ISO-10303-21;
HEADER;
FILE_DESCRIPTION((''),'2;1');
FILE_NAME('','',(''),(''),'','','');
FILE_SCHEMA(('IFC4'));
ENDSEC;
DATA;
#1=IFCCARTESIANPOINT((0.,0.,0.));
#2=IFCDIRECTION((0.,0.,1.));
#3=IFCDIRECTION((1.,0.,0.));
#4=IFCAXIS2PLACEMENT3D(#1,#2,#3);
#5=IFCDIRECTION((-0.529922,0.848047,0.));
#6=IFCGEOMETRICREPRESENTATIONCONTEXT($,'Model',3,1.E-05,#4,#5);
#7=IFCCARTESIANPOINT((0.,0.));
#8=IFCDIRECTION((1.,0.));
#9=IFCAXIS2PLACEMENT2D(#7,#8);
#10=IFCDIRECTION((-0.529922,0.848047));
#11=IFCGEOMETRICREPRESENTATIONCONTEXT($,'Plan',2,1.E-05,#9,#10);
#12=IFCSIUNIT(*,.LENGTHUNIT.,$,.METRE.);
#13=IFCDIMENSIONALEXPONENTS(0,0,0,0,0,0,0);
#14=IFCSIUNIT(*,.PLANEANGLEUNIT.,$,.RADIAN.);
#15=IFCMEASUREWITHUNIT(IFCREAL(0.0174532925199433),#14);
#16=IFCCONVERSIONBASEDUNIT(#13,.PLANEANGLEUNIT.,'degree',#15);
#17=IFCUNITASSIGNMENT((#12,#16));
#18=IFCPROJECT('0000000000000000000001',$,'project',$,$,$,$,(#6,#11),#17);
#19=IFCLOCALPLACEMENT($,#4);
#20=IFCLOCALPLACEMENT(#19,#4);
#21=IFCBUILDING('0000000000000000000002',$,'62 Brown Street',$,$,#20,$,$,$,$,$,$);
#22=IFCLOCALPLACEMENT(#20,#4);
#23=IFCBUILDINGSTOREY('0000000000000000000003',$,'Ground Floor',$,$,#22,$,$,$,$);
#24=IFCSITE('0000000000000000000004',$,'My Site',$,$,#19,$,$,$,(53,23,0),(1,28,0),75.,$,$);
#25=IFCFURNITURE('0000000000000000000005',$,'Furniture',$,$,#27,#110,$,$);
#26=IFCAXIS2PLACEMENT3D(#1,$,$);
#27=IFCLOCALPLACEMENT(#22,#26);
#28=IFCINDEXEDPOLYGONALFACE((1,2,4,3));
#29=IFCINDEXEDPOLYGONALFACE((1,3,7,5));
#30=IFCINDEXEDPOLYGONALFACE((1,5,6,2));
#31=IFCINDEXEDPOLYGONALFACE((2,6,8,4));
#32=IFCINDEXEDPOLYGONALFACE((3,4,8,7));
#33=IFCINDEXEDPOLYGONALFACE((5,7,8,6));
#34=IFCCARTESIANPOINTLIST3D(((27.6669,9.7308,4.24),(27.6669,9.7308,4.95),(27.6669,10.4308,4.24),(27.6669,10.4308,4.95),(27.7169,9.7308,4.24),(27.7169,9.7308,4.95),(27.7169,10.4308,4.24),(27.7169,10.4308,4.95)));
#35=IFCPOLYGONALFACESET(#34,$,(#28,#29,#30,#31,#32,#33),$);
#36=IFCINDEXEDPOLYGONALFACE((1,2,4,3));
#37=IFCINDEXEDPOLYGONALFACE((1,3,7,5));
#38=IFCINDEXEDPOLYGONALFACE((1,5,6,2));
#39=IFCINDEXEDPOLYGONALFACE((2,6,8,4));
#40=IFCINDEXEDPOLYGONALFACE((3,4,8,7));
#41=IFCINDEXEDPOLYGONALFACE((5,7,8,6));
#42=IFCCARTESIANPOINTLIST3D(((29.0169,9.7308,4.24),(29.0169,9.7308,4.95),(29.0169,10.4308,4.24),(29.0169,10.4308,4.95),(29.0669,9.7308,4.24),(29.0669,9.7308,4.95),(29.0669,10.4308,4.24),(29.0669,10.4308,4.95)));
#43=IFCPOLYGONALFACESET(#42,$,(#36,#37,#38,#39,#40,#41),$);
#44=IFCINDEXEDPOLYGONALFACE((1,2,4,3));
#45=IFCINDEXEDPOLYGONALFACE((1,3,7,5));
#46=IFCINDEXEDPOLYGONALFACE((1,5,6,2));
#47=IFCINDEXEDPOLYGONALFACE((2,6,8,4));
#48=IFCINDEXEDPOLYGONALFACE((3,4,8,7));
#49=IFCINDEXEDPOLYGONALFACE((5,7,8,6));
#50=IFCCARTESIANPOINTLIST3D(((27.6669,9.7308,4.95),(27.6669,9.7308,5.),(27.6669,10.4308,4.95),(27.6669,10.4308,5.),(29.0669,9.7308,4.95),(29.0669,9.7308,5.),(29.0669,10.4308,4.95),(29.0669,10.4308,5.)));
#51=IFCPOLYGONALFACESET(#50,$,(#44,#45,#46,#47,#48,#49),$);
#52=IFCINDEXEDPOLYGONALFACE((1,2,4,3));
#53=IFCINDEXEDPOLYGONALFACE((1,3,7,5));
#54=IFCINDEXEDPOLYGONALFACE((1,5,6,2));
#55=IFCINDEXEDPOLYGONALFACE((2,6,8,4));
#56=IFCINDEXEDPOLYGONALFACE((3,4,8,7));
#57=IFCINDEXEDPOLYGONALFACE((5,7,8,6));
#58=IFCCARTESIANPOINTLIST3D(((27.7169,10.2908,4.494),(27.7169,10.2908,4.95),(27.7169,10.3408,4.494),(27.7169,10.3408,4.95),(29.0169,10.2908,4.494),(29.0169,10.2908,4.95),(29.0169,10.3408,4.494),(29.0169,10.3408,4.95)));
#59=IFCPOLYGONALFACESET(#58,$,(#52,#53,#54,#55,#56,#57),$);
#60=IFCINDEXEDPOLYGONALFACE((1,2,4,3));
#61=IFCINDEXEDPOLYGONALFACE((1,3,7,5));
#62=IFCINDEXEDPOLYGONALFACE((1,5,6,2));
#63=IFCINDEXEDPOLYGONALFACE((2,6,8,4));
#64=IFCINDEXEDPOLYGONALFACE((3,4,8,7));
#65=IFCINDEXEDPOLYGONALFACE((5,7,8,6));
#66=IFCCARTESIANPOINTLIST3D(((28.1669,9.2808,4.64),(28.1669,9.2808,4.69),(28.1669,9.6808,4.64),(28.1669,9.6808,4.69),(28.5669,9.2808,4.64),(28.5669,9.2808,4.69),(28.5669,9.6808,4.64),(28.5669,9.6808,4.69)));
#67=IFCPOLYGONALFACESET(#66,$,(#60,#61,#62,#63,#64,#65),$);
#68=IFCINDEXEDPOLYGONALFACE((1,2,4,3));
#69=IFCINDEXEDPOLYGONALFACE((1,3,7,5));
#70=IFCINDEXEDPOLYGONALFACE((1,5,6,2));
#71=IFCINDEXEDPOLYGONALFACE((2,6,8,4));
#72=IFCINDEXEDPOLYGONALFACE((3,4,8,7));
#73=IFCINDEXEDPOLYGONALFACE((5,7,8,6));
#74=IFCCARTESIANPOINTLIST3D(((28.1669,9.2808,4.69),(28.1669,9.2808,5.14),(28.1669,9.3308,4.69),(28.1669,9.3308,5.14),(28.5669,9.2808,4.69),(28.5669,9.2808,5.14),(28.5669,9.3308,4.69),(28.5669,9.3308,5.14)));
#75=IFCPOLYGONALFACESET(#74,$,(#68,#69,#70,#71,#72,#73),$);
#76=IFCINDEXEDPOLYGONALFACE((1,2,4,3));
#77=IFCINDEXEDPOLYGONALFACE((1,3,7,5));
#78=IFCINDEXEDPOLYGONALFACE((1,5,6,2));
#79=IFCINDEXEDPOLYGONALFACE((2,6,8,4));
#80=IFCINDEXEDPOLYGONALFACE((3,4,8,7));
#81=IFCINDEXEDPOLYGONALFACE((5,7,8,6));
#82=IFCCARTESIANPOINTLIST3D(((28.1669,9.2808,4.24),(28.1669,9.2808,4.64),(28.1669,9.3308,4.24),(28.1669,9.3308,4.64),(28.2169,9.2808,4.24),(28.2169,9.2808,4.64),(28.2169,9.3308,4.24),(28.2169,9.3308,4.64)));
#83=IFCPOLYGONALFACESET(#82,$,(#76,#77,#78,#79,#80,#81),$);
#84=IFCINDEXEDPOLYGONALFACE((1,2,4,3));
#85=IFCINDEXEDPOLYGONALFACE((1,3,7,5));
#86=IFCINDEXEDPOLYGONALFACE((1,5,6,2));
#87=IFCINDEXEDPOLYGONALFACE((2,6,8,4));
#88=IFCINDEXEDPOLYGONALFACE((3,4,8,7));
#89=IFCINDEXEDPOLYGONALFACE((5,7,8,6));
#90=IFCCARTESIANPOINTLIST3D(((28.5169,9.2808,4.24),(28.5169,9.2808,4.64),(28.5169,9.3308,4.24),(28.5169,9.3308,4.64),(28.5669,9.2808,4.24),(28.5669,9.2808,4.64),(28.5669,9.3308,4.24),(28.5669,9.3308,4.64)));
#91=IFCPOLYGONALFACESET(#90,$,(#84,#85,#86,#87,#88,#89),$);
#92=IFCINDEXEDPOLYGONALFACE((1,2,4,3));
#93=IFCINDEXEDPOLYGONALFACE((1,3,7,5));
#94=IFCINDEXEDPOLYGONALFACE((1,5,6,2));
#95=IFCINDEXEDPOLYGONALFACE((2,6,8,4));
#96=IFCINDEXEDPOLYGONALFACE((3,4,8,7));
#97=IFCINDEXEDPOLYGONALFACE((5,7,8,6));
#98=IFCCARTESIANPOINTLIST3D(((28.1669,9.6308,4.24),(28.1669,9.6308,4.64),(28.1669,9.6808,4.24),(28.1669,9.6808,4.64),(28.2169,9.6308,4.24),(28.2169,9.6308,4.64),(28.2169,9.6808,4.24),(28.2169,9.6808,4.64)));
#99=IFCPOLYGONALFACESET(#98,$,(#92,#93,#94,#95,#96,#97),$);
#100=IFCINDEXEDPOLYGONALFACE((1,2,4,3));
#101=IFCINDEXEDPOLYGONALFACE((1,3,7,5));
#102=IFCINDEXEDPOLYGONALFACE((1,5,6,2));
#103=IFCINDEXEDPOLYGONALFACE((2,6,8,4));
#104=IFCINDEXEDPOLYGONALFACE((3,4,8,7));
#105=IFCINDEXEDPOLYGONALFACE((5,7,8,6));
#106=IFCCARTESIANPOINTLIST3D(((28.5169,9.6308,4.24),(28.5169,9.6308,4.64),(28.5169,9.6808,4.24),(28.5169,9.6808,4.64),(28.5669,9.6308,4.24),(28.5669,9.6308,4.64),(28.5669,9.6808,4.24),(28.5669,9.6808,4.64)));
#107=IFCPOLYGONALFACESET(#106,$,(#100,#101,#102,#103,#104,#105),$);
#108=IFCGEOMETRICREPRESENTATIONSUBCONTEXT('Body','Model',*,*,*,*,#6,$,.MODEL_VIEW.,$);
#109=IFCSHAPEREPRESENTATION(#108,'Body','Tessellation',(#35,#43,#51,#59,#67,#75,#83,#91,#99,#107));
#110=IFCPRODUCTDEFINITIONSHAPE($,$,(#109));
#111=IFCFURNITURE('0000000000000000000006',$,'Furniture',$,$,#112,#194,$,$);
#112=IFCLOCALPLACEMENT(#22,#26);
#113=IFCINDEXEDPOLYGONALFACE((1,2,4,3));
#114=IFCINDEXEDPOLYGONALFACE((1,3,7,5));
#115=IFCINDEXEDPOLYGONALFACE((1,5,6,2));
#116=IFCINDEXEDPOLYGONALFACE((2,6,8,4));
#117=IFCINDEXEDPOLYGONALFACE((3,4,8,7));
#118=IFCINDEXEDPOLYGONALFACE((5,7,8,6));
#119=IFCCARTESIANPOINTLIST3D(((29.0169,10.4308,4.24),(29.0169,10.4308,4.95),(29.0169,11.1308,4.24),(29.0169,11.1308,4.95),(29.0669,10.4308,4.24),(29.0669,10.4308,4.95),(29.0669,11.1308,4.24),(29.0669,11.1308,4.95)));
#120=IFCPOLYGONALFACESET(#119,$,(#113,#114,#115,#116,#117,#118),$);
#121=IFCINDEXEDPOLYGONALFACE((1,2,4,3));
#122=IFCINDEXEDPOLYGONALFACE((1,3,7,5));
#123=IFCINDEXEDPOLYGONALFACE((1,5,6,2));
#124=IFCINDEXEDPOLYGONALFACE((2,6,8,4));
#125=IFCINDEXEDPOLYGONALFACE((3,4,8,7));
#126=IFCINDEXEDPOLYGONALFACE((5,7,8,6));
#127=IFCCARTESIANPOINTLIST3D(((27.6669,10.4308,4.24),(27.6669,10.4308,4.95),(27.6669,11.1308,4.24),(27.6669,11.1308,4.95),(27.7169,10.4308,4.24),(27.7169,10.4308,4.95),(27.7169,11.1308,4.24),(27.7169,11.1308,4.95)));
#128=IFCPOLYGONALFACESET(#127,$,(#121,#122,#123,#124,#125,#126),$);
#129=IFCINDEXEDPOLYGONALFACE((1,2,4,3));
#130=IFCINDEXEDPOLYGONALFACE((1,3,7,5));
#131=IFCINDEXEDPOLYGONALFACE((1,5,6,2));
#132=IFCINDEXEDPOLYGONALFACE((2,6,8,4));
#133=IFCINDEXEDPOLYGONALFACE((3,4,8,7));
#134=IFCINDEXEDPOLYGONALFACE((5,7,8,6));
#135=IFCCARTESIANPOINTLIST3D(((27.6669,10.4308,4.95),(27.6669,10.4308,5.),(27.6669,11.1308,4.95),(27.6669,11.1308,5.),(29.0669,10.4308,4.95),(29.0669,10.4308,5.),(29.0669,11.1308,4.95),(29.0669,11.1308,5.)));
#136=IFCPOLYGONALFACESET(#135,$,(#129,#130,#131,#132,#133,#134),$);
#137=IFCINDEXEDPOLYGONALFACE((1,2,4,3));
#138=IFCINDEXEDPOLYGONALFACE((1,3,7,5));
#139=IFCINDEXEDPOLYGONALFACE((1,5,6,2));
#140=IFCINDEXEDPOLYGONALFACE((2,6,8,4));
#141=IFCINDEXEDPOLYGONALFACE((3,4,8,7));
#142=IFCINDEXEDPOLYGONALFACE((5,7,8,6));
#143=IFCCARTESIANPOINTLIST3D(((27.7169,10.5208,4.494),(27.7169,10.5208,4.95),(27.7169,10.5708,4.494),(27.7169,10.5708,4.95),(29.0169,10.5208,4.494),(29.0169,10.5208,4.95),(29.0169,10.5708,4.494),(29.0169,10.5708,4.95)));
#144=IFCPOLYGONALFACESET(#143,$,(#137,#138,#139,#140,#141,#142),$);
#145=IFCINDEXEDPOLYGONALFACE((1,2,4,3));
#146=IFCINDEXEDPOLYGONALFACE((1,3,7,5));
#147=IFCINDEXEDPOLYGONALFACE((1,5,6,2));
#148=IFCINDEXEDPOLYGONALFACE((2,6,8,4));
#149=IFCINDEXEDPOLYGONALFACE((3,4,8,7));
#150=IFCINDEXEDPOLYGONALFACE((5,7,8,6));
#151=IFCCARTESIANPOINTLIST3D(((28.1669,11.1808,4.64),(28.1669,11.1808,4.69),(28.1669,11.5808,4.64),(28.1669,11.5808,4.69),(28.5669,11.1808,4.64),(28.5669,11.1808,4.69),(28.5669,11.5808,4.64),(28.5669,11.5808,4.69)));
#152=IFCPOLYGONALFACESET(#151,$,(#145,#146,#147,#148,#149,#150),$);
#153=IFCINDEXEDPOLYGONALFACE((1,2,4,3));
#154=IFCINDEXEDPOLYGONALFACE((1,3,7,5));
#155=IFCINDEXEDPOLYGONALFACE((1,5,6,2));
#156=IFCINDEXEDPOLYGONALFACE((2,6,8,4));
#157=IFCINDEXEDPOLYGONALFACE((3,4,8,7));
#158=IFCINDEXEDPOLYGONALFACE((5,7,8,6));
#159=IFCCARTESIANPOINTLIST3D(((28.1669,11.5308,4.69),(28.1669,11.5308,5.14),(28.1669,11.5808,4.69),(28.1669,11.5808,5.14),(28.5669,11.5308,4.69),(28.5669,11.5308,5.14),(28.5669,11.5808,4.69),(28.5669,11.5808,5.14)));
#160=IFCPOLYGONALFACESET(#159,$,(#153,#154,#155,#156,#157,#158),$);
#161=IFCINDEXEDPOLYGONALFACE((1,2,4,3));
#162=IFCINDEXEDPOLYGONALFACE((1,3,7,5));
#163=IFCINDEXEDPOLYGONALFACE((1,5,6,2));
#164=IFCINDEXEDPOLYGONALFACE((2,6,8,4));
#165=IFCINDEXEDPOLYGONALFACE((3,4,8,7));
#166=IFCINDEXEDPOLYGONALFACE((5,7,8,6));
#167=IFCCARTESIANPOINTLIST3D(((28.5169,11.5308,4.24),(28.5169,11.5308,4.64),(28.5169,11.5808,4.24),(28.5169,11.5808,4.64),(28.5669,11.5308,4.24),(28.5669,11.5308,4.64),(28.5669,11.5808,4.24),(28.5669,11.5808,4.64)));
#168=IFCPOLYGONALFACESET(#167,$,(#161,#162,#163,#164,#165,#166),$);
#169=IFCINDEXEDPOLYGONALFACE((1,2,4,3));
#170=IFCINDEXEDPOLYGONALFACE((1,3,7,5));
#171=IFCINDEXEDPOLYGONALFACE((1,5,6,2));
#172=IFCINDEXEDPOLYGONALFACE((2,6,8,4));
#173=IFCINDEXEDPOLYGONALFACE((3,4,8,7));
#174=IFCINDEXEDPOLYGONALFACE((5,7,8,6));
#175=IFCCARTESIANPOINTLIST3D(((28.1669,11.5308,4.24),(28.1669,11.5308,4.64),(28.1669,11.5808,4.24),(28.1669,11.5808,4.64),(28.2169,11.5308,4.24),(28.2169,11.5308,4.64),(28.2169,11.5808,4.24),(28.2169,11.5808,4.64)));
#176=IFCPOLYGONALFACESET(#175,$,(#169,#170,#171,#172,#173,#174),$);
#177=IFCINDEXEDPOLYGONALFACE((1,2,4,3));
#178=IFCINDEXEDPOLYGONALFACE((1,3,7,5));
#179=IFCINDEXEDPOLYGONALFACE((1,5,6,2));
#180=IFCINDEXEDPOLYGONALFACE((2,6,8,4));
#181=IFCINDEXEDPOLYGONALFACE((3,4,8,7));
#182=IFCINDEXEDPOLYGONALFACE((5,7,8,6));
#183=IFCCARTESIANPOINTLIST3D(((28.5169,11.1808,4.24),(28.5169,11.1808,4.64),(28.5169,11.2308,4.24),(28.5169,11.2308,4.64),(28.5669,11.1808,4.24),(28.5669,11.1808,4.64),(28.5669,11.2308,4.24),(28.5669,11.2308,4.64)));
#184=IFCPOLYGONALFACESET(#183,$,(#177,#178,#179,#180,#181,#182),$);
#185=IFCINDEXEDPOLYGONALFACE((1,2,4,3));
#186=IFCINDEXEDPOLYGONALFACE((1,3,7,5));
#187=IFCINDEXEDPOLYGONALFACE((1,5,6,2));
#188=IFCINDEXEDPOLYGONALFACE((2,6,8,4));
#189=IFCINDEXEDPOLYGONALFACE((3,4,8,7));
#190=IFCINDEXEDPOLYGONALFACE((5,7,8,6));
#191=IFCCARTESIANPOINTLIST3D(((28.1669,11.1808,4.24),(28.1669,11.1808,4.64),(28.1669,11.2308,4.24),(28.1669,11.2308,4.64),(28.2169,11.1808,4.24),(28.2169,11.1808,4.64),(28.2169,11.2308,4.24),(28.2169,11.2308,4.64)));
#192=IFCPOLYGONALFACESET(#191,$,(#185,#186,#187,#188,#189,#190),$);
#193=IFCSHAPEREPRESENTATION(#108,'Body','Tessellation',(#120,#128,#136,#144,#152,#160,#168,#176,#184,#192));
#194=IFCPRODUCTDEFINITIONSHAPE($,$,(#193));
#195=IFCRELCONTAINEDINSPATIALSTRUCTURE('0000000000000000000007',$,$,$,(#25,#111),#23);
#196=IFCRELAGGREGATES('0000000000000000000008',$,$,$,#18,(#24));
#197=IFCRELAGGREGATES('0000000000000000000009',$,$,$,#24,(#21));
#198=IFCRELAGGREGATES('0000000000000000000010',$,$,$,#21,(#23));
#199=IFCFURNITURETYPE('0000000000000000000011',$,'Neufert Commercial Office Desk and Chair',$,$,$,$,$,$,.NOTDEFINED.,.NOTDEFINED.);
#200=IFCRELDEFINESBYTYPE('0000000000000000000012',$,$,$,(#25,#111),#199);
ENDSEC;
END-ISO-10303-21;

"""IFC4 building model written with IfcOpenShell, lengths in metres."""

from ifc_helpers import new_model, entity, si_unit, converted_unit, direction, frame, origin_with_axes, origin_2d_with_axis, place, context, subcontext, project, spatial, line, indexed_curve, outline, extrude, shape, source, transform, mapped, type_object, type_shapes, element, save


model = new_model("IFC4")

# Units and contexts
model_context = context("Model", 3, precision=1e-05, world=origin_with_axes(), true_north=direction((-0.529922, 0.848047, 0.0)))
plan_context = context("Plan", 2, precision=1e-05, world=origin_2d_with_axis(), true_north=direction((-0.529922, 0.848047)))
body_context_1 = subcontext(model_context, "Body", "Model", "MODEL_VIEW")
body_context_2 = subcontext(plan_context, "Body", "Plan", "PLAN_VIEW")
ifc_project = project(units=[si_unit("LENGTHUNIT", "METRE"), converted_unit("PLANEANGLEUNIT", "degree", entity("IfcReal", 0.0174532925199433), si_unit("PLANEANGLEUNIT", "RADIAN"), dimensions=[0, 0, 0, 0, 0, 0, 0])], contexts=[model_context, plan_context])

# Site, building, storey
site_placement = place(None, origin_with_axes())
site = spatial("IfcSite", under=ifc_project, at=site_placement, Name="My Site", RefLatitude=(53, 23, 0), RefLongitude=(1, 28, 0), RefElevation=75.0)
building_placement = place(site_placement, origin_with_axes())
building = spatial("IfcBuilding", under=site, at=building_placement, Name="62 Brown Street")
storey_placement = place(building_placement, origin_with_axes())
storey = spatial("IfcBuildingStorey", under=building, at=storey_placement, Name="Ground Floor")

# Furniture
furniture_type_1 = type_object("IfcFurnitureType", Name="Neufert Commercial Office Desk and Chair", AssemblyPlace="NOTDEFINED", PredefinedType="NOTDEFINED")
shared_shape_1 = source(origin_with_axes(), body_context_1, "Body", "SweptSolid", [
    extrude(outline(indexed_curve([(0.0, 0.0), (0.05, 0.0), (0.05, 0.7), (0.0, 0.7)], segments=[line(1, 2, 3, 4, 1)])), frame((0.0, 0.45, 0.0), z_axis=(0.0, 0.0, 1.0), x_axis=(1.0, 0.0, 0.0)), (0.0, 0.0, 1.0), 0.71),
    extrude(outline(indexed_curve([(0.0, 0.0), (0.05, 0.0), (0.05, 0.7), (0.0, 0.7)], segments=[line(1, 2, 3, 4, 1)])), frame((1.35, 0.45, 0.0), z_axis=(0.0, 0.0, 1.0), x_axis=(1.0, 0.0, 0.0)), (0.0, 0.0, 1.0), 0.71),
    extrude(outline(indexed_curve([(0.0, 0.0), (1.4, 0.0), (1.4, 0.7), (0.0, 0.7)], segments=[line(1, 2, 3, 4, 1)])), frame((0.0, 0.45, 0.71), z_axis=(0.0, 0.0, 1.0), x_axis=(1.0, 0.0, 0.0)), (0.0, 0.0, 1.0), 0.05),
    extrude(outline(indexed_curve([(0.05, 0.56), (1.35, 0.56), (1.35, 0.61), (0.05, 0.61)], segments=[line(1, 2, 3, 4, 1)])), frame((0.0, 0.45, 0.254), z_axis=(0.0, 0.0, 1.0), x_axis=(1.0, 0.0, 0.0)), (0.0, 0.0, 1.0), 0.456),
    extrude(outline(indexed_curve([(-0.2, 0.0), (0.2, 0.0), (0.2, 0.4), (-0.2, 0.4)], segments=[line(1, 2, 3, 4, 1)])), frame((0.7, 0.0, 0.45), z_axis=(0.0, 0.0, 1.0), x_axis=(1.0, 0.0, 0.0)), (0.0, 0.0, -1.0), 0.05),
    extrude(outline(indexed_curve([(-0.2, 0.0), (0.2, 0.0), (0.2, 0.05), (-0.2, 0.05)], segments=[line(1, 2, 3, 4, 1)])), frame((0.7, 0.0, 0.9), z_axis=(0.0, 0.0, 1.0), x_axis=(1.0, 0.0, 0.0)), (0.0, 0.0, -1.0), 0.45),
    extrude(outline(indexed_curve([(-0.2, 0.0), (-0.15, 0.0), (-0.15, 0.05), (-0.2, 0.05)], segments=[line(1, 2, 3, 4, 1)])), frame((0.7, 0.0, 0.0), z_axis=(0.0, 0.0, 1.0), x_axis=(1.0, 0.0, 0.0)), (0.0, 0.0, 1.0), 0.4),
    extrude(outline(indexed_curve([(0.2, 0.0), (0.15, 0.0), (0.15, 0.05), (0.2, 0.05)], segments=[line(1, 2, 3, 4, 1)])), frame((0.7, 0.0, 0.0), z_axis=(0.0, 0.0, 1.0), x_axis=(1.0, 0.0, 0.0)), (0.0, 0.0, 1.0), 0.4),
    extrude(outline(indexed_curve([(-0.2, 0.4), (-0.15, 0.4), (-0.15, 0.35), (-0.2, 0.35)], segments=[line(1, 2, 3, 4, 1)])), frame((0.7, 0.0, 0.0), z_axis=(0.0, 0.0, 1.0), x_axis=(1.0, 0.0, 0.0)), (0.0, 0.0, 1.0), 0.4),
    extrude(outline(indexed_curve([(0.2, 0.4), (0.15, 0.4), (0.15, 0.35), (0.2, 0.35)], segments=[line(1, 2, 3, 4, 1)])), frame((0.7, 0.0, 0.0), z_axis=(0.0, 0.0, 1.0), x_axis=(1.0, 0.0, 0.0)), (0.0, 0.0, 1.0), 0.4),
])
shared_shape_2 = source(origin_with_axes(), body_context_2, "Body", "Curve2D", [
    entity("IfcIndexedPolyCurve", entity("IfcCartesianPointList2D", [[0.0, 0.45], [1.4, 0.45], [1.4, 1.15], [0.0, 1.15]]), [entity("IfcLineIndex", [1, 2, 3, 4, 1])]),
    entity("IfcIndexedPolyCurve", entity("IfcCartesianPointList2D", [[0.5, 0.4], [0.9, 0.4]])),
    entity("IfcIndexedPolyCurve", entity("IfcCartesianPointList2D", [[0.5, 0.4], [0.5, 0.2], [0.5586, 0.0586], [0.7, 0.0], [0.8414, 0.0586], [0.9, 0.2], [0.9, 0.4]]), [entity("IfcLineIndex", [1, 2]), entity("IfcArcIndex", [2, 3, 4]), entity("IfcArcIndex", [4, 5, 6]), entity("IfcLineIndex", [6, 7])]),
    entity("IfcIndexedPolyCurve", entity("IfcCartesianPointList2D", [[0.54, 0.4], [0.54, 0.2], [0.5869, 0.0869], [0.7, 0.04], [0.8131, 0.0869], [0.86, 0.2], [0.86, 0.4]]), [entity("IfcLineIndex", [1, 2]), entity("IfcArcIndex", [2, 3, 4]), entity("IfcArcIndex", [4, 5, 6]), entity("IfcLineIndex", [6, 7])]),
])
type_shapes(furniture_type_1, [shared_shape_1, shared_shape_2])
for number, where, z_axis, x_axis, name in (
    (1, (27.6669, 9.2808, 4.24), (0.0, 0.0, 1.0), (1.0, 0.0, 0.0), "Furniture"),
    (2, (29.0669, 11.5808, 4.24), (0.0, 0.0, 1.0), (-1.0, 0.0, 0.0), "Furniture"),
):
    element("IfcFurniture", number, at=place(storey_placement, frame(where, z_axis=z_axis, x_axis=x_axis)), inside=storey, type_object=furniture_type_1, Name=name, shapes=[
        shape(body_context_1, "Body", "MappedRepresentation", [mapped(shared_shape_1, transform((0.0, 0.0, 0.0), x_axis=(1.0, 0.0, 0.0), y_axis=(0.0, 1.0, 0.0), z_axis=(0.0, 0.0, 1.0), scale=1.0))]),
        shape(body_context_2, "Body", "MappedRepresentation", [mapped(shared_shape_2, transform((0.0, 0.0, 0.0), x_axis=(1.0, 0.0, 0.0), y_axis=(0.0, 1.0, 0.0), z_axis=(0.0, 0.0, 1.0), scale=1.0))]),
    ])

save(model, "model.ifc")
